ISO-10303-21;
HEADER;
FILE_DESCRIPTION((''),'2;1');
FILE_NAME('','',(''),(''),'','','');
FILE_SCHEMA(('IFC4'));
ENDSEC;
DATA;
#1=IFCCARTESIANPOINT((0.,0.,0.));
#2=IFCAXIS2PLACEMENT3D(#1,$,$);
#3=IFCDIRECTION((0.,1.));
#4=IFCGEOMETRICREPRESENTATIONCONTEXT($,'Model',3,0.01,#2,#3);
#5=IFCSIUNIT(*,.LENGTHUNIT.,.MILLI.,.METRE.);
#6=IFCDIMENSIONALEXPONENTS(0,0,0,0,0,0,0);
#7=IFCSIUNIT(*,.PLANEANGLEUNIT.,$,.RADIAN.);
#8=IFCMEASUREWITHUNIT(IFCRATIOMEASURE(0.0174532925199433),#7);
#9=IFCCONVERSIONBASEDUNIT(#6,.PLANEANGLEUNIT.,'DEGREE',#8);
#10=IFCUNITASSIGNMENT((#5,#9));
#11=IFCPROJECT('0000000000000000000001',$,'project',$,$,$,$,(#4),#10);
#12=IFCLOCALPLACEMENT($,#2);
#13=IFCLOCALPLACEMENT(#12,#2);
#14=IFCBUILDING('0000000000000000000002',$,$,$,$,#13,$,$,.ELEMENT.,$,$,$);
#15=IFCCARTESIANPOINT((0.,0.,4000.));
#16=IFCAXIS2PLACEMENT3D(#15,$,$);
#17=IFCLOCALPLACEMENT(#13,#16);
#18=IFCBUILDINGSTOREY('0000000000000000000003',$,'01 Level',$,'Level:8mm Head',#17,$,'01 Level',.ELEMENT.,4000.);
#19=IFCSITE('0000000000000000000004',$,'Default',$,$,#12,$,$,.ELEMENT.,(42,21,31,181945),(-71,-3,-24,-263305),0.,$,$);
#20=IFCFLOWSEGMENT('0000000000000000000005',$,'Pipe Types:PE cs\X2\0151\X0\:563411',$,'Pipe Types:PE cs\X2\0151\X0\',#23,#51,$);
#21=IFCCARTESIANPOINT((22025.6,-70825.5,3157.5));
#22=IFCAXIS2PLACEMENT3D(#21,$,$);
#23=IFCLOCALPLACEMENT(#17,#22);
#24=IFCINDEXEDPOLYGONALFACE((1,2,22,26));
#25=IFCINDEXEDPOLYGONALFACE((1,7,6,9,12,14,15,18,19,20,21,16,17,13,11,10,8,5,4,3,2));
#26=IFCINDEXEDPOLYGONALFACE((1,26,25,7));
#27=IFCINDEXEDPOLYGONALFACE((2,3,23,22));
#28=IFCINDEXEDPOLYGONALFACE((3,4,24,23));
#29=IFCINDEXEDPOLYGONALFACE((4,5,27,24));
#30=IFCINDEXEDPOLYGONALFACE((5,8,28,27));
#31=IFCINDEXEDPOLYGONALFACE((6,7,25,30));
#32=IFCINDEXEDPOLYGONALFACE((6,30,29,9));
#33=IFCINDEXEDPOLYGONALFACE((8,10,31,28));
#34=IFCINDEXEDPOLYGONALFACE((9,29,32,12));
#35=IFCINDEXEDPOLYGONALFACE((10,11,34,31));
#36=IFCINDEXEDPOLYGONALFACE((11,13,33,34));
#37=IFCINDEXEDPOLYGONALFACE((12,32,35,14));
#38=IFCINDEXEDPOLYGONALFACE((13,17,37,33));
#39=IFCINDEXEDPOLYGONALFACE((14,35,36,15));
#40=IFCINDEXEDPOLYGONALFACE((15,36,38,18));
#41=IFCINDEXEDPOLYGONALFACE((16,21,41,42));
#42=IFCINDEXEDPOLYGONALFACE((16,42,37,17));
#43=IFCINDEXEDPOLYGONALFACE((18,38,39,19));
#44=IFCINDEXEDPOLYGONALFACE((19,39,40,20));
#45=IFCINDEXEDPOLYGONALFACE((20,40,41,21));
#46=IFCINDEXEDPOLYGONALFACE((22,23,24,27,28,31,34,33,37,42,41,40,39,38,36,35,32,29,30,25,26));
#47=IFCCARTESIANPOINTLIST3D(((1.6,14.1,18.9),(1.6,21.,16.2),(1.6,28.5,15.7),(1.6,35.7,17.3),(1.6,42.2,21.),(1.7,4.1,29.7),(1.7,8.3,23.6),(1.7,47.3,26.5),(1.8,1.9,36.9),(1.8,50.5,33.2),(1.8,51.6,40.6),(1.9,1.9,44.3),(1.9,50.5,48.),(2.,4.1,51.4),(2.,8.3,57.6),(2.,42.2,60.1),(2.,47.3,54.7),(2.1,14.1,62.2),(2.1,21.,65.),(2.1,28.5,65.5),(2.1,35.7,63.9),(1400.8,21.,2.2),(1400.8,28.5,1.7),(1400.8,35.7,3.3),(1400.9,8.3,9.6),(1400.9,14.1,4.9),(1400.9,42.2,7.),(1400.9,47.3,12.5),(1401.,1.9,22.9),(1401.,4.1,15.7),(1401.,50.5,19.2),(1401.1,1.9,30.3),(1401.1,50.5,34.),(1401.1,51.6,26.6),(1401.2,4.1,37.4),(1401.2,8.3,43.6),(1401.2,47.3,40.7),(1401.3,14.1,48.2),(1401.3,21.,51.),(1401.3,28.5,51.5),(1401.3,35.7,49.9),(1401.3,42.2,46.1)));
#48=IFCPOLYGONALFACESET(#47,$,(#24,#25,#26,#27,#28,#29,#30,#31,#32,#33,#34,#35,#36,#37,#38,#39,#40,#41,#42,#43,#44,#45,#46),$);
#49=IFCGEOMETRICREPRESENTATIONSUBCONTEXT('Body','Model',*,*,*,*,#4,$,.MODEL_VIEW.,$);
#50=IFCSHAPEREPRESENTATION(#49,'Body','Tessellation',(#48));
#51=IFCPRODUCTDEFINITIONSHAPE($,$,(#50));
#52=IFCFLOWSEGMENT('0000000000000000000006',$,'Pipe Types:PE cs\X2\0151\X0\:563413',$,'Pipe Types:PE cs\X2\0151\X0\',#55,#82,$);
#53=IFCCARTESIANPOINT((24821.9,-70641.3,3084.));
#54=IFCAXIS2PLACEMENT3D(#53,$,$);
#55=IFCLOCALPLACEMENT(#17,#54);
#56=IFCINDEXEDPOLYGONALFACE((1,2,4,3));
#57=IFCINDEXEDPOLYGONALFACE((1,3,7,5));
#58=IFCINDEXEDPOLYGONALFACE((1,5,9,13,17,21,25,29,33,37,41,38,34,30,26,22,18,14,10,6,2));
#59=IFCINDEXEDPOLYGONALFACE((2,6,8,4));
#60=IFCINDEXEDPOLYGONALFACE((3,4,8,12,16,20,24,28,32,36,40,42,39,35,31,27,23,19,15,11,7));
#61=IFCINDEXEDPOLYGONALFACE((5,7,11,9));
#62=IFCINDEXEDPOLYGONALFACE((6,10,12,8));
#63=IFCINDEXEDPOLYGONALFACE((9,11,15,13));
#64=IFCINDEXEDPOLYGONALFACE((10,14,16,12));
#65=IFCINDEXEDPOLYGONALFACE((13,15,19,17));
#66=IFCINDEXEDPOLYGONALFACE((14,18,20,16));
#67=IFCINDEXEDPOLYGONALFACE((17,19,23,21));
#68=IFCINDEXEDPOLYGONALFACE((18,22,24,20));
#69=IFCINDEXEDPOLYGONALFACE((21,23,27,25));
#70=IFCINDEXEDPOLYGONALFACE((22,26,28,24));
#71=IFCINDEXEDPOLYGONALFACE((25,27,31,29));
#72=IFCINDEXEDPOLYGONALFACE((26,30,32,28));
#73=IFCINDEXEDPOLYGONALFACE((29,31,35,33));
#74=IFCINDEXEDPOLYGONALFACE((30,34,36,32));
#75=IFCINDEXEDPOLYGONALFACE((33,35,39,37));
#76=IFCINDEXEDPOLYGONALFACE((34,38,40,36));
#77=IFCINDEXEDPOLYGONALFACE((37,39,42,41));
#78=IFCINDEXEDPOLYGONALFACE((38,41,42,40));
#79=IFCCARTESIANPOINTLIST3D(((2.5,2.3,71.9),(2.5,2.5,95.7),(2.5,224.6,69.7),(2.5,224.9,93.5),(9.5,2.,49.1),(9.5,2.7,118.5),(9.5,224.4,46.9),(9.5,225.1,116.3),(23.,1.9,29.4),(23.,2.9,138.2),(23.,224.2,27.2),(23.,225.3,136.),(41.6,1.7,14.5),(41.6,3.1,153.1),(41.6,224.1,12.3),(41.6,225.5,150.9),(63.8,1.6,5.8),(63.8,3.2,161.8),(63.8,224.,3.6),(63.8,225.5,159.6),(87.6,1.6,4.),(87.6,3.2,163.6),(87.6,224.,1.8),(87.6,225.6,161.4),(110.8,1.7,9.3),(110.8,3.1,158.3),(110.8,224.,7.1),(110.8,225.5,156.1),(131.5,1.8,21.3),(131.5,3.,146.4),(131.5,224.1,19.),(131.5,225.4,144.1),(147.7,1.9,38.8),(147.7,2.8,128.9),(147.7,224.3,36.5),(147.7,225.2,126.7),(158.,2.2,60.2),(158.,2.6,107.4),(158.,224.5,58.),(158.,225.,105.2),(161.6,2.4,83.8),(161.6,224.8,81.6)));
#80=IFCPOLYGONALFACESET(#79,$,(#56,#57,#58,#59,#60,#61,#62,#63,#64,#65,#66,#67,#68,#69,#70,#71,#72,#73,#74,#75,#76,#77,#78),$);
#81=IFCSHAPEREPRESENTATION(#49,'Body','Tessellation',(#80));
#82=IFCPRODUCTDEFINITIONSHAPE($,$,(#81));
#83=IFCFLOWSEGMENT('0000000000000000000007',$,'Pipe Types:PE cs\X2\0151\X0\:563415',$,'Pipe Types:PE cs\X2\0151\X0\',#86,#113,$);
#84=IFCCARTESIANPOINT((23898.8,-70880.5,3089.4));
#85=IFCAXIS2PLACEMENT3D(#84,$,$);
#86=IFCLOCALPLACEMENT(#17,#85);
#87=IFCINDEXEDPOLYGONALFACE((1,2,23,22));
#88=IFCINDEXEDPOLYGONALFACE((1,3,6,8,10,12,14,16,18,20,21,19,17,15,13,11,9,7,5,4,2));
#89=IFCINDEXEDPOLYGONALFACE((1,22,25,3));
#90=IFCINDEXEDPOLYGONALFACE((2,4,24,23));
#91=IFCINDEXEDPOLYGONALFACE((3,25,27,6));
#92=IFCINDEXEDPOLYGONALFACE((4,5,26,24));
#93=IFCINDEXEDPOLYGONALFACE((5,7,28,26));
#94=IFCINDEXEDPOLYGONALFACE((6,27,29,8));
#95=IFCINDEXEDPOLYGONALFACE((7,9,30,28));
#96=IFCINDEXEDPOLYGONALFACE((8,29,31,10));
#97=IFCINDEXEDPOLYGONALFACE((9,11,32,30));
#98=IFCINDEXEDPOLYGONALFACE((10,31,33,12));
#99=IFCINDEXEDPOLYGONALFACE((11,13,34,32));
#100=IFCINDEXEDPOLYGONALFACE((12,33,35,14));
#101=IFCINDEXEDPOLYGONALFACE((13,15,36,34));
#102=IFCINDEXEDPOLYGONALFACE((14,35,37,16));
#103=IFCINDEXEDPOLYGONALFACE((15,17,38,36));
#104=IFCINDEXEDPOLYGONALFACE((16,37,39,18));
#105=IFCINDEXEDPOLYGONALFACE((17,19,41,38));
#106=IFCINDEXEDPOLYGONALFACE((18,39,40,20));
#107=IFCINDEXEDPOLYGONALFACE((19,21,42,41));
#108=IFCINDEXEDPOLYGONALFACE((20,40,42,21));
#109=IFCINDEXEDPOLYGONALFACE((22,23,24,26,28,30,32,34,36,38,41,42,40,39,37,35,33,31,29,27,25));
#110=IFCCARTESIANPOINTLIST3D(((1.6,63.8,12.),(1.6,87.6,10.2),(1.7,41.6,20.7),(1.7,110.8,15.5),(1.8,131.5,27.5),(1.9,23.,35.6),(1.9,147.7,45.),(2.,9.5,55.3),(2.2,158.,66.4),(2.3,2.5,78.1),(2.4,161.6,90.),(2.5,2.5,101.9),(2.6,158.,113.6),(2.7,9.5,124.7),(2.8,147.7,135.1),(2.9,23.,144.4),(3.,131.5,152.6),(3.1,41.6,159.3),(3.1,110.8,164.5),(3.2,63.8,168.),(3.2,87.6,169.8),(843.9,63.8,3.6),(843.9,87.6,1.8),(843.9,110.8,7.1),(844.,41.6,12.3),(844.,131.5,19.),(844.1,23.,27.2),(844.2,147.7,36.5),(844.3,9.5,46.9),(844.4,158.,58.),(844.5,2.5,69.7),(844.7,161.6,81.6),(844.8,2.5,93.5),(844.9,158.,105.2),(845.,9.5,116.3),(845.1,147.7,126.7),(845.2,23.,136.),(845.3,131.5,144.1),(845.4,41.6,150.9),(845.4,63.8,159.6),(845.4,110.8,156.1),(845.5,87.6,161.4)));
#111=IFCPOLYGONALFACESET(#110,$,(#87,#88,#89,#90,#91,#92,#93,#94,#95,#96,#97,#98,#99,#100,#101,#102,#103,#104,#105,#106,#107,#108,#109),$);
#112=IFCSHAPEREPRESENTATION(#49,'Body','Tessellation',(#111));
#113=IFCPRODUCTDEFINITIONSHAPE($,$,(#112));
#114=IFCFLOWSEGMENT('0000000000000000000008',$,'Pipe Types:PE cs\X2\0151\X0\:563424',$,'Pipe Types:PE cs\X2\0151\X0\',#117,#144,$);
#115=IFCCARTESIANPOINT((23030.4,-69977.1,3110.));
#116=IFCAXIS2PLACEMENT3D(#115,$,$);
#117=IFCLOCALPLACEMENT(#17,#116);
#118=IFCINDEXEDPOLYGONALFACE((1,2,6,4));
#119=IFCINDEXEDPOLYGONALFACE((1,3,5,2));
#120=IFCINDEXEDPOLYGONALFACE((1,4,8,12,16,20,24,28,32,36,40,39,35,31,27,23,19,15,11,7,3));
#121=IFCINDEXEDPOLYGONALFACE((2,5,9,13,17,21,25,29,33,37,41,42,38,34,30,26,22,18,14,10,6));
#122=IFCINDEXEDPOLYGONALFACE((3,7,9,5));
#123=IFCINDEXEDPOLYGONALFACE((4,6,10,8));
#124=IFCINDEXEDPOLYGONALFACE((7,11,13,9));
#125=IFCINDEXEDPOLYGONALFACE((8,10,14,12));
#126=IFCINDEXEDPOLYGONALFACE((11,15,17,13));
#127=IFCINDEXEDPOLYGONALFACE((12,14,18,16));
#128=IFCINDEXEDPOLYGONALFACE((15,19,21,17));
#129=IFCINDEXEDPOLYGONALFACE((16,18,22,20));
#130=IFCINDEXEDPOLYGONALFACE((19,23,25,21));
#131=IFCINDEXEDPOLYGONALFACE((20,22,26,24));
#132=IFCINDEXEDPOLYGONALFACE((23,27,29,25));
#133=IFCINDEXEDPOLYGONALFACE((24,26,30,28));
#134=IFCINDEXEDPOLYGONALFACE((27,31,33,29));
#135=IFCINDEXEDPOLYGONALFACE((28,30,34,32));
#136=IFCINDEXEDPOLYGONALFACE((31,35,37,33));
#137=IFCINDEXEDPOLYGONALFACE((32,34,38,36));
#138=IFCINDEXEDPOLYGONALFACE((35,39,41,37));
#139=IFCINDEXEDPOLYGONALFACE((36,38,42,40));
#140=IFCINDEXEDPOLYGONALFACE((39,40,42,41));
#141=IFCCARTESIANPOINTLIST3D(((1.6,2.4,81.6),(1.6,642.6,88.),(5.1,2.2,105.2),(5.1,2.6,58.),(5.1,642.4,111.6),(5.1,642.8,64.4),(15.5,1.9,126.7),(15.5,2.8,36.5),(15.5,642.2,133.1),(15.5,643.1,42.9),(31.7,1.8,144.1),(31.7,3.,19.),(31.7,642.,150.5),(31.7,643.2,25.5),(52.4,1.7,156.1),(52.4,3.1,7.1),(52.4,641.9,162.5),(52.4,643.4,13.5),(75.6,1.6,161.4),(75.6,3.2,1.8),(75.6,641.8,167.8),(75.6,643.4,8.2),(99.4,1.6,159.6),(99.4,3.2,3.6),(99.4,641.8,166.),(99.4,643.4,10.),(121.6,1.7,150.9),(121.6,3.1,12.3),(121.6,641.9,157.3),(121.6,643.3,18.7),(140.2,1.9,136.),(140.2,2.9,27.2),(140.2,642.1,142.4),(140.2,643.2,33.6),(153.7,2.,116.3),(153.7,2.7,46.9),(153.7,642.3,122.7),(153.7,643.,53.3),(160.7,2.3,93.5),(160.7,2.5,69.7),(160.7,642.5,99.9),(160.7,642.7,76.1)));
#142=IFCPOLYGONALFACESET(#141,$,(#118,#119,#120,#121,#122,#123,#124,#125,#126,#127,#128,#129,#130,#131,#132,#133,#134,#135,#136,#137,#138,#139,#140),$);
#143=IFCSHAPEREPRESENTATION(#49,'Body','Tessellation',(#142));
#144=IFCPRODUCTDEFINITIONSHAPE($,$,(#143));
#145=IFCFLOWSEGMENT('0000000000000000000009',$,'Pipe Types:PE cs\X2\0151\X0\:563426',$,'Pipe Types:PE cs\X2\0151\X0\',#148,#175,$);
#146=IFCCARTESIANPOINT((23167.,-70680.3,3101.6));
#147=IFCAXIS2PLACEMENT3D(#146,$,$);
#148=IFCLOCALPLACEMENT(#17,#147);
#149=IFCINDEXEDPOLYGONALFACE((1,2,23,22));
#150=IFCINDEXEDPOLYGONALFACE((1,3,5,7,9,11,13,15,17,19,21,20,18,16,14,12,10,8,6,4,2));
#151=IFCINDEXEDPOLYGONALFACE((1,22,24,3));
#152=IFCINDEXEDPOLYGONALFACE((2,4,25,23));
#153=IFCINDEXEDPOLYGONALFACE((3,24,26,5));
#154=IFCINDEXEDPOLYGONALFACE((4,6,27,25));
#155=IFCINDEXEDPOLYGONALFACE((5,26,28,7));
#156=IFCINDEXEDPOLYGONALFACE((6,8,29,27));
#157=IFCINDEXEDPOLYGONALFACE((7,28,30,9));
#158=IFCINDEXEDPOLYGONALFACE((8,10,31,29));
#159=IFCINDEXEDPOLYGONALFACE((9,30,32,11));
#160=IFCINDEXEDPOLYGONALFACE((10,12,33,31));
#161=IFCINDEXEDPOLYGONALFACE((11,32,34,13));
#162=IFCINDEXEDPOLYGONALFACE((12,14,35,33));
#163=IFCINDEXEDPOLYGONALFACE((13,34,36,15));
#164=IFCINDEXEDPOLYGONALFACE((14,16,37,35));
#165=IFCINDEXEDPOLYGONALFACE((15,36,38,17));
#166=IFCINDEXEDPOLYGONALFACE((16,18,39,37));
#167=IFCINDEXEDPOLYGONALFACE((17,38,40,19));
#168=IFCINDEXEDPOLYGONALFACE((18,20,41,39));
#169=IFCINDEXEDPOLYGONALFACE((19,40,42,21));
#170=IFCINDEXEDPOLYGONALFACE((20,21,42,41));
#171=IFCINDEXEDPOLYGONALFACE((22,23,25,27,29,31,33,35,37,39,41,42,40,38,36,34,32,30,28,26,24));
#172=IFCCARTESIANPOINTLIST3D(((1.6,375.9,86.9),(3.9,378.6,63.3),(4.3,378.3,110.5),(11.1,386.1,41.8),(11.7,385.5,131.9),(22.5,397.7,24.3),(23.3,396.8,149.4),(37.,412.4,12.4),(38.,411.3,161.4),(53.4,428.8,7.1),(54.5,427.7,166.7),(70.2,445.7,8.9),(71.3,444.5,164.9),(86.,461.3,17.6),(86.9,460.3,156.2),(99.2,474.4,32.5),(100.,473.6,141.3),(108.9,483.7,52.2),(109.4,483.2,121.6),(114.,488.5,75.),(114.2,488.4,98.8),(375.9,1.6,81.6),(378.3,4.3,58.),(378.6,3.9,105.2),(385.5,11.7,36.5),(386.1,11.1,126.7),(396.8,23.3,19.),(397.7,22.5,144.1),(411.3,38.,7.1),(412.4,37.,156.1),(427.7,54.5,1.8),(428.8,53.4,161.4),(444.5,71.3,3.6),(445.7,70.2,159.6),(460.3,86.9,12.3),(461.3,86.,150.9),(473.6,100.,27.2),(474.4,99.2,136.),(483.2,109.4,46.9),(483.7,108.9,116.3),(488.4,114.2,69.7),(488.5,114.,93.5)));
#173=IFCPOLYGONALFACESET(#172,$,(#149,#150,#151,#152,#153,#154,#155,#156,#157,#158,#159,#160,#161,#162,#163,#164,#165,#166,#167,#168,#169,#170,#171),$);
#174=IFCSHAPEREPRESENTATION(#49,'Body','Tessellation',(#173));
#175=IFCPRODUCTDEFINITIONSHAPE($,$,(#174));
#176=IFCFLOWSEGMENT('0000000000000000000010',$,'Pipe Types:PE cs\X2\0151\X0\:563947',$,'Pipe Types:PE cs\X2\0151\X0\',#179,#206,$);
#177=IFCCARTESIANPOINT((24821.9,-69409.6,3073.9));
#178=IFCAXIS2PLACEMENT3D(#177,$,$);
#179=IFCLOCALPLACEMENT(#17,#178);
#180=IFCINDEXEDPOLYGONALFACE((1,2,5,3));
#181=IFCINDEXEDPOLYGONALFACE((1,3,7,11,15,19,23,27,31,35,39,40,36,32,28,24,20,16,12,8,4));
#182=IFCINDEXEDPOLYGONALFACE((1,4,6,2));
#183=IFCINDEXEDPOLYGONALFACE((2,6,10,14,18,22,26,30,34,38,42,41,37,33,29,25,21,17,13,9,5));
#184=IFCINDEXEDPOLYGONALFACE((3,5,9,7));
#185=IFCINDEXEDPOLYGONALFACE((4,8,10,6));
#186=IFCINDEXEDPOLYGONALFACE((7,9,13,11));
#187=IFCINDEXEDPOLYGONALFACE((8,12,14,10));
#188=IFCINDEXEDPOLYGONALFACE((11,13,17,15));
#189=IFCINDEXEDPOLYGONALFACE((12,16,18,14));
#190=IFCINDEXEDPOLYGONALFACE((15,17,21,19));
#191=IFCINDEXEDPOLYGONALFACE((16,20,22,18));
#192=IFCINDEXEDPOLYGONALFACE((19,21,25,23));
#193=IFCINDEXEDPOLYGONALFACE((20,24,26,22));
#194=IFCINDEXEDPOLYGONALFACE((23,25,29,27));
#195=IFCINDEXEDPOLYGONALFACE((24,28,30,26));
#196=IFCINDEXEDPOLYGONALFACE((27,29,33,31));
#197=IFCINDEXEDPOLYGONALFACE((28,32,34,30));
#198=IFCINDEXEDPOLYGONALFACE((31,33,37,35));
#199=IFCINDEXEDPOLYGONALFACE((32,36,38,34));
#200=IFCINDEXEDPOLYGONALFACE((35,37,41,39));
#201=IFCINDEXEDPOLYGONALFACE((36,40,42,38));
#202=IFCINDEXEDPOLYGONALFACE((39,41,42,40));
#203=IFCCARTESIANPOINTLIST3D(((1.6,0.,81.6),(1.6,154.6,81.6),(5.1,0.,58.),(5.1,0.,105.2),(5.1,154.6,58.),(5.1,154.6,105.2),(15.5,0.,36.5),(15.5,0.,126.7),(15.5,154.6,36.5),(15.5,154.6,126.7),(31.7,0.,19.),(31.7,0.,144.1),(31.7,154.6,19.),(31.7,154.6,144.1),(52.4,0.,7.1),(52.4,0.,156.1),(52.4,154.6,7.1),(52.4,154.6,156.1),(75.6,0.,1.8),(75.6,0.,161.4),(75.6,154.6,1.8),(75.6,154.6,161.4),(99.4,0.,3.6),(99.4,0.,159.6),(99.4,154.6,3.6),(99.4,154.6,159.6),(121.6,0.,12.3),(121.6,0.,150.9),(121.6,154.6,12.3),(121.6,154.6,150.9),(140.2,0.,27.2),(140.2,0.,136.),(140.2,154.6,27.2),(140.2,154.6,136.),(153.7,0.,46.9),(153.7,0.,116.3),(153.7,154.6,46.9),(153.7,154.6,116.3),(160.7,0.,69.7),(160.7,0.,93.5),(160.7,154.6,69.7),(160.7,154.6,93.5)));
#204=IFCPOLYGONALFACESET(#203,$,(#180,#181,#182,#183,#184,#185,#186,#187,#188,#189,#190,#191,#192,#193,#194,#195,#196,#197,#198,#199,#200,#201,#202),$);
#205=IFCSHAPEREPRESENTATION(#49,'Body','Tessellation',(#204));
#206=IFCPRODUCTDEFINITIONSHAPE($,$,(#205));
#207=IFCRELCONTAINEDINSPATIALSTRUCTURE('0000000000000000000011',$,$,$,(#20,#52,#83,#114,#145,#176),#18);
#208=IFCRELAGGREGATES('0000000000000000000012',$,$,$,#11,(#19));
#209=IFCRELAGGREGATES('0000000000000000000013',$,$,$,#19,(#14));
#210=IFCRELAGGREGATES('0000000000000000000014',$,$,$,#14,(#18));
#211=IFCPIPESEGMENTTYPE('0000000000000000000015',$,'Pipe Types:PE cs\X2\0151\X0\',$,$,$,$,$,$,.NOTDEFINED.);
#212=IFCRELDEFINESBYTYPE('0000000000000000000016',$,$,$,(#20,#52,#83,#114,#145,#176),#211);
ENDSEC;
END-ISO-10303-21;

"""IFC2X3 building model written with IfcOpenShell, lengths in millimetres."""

from ifc_helpers import new_model, entity, si_unit, converted_unit, direction, frame, frame_2d, origin, origin_2d_with_axis, place, context, subcontext, project, spatial, circle, extrude, type_object, element, save


model = new_model("IFC2X3")

# Units and contexts
model_context = context("Model", 3, precision=0.01, world=origin(), true_north=direction((0.0, 1.0)))
body_context = subcontext(model_context, "Body", "Model", "MODEL_VIEW")
ifc_project = project(units=[si_unit("LENGTHUNIT", "METRE", prefix="MILLI"), converted_unit("PLANEANGLEUNIT", "DEGREE", entity("IfcRatioMeasure", 0.0174532925199433), si_unit("PLANEANGLEUNIT", "RADIAN"), dimensions=[0, 0, 0, 0, 0, 0, 0])], contexts=[model_context])

# Site, building, storey
site_placement = place(None, origin())
site = spatial("IfcSite", under=ifc_project, at=site_placement, Name="Default", CompositionType="ELEMENT", RefLatitude=(42, 21, 31, 181945), RefLongitude=(-71, -3, -24, -263305), RefElevation=0.0)
building_placement = place(site_placement, origin())
building = spatial("IfcBuilding", under=site, at=building_placement, CompositionType="ELEMENT")
storey_placement = place(building_placement, frame((0.0, 0.0, 4000.0)))
storey = spatial("IfcBuildingStorey", under=building, at=storey_placement, Name="01 Level", ObjectType="Level:8mm Head", LongName="01 Level", CompositionType="ELEMENT", Elevation=4000.0)

# Flow segments
pipe_segment_type = type_object("IfcPipeSegmentType", Name="Pipe Types:PE cső", PredefinedType="NOTDEFINED")
flow_segment_1_placement = place(storey_placement, frame((22025.6, -70825.5, 3157.5)))
element("IfcFlowSegment", 1, at=flow_segment_1_placement, inside=storey, type_object=pipe_segment_type, Name="Pipe Types:PE cső:563411", ObjectType="Pipe Types:PE cső", context=body_context, shape_type="SweptSolid", body=[
    extrude(circle(Radius=25.0, at=origin_2d_with_axis()), frame((1401.1, 26.6, 26.6), z_axis=(-0.99995, 0.0, 0.01), x_axis=(0.0, 1.0, 0.0)), (0.0, 0.0, 1.0), 1399.3),
])
flow_segment_2_placement = place(storey_placement, frame((24821.9, -70641.3, 3084.0)))
element("IfcFlowSegment", 2, at=flow_segment_2_placement, inside=storey, type_object=pipe_segment_type, Name="Pipe Types:PE cső:563413", ObjectType="Pipe Types:PE cső", context=body_context, shape_type="SweptSolid", body=[
    extrude(circle(Radius=80.0, at=origin_2d_with_axis()), frame((81.6, 2.4, 83.8), z_axis=(0.0, 0.99995, -0.01), x_axis=(1.0, 0.0, 0.0)), (0.0, 0.0, 1.0), 222.4),
])
flow_segment_3_placement = place(storey_placement, frame((23898.8, -70880.5, 3089.4)))
element("IfcFlowSegment", 3, at=flow_segment_3_placement, inside=storey, type_object=pipe_segment_type, Name="Pipe Types:PE cső:563415", ObjectType="Pipe Types:PE cső", context=body_context, shape_type="SweptSolid", body=[
    extrude(circle(Radius=80.0, at=origin_2d_with_axis()), frame((844.7, 81.6, 81.6), z_axis=(-0.99995, 0.0, 0.01), x_axis=(0.0, 1.0, 0.0)), (0.0, 0.0, 1.0), 842.3),
])
flow_segment_4_placement = place(storey_placement, frame((23030.4, -69977.1, 3110.0)))
element("IfcFlowSegment", 4, at=flow_segment_4_placement, inside=storey, type_object=pipe_segment_type, Name="Pipe Types:PE cső:563424", ObjectType="Pipe Types:PE cső", context=body_context, shape_type="SweptSolid", body=[
    extrude(circle(Radius=80.0, at=origin_2d_with_axis()), frame((81.6, 2.4, 81.6), z_axis=(0.0, 0.99995, 0.01), x_axis=(-1.0, 0.0, 0.0)), (0.0, 0.0, 1.0), 640.2),
])
flow_segment_5_placement = place(storey_placement, frame((23167.0, -70680.3, 3101.6)))
element("IfcFlowSegment", 5, at=flow_segment_5_placement, inside=storey, type_object=pipe_segment_type, Name="Pipe Types:PE cső:563426", ObjectType="Pipe Types:PE cső", context=body_context, shape_type="SweptSolid", body=[
    extrude(circle(Radius=80.0, at=frame_2d((0.0, 0.0), x_axis=(1.0, 0.0))), frame((432.5, 58.2, 81.6), z_axis=(-0.707071, 0.707071, 0.01), x_axis=(-0.707107, -0.707107, 0.0)), (0.0, 0.0, 1.0), 529.4),
])
flow_segment_6_placement = place(storey_placement, frame((24821.9, -69409.6, 3073.9)))
element("IfcFlowSegment", 6, at=flow_segment_6_placement, inside=storey, type_object=pipe_segment_type, Name="Pipe Types:PE cső:563947", ObjectType="Pipe Types:PE cső", context=body_context, shape_type="SweptSolid", body=[
    extrude(circle(Radius=80.0, at=frame_2d((0.0, 0.0), x_axis=(1.0, 0.0))), frame((81.6, 0.0, 81.6), z_axis=(0.0, 1.0, 0.0), x_axis=(-1.0, 0.0, 0.0)), (0.0, 0.0, 1.0), 154.6),
])

save(model, "model.ifc")
